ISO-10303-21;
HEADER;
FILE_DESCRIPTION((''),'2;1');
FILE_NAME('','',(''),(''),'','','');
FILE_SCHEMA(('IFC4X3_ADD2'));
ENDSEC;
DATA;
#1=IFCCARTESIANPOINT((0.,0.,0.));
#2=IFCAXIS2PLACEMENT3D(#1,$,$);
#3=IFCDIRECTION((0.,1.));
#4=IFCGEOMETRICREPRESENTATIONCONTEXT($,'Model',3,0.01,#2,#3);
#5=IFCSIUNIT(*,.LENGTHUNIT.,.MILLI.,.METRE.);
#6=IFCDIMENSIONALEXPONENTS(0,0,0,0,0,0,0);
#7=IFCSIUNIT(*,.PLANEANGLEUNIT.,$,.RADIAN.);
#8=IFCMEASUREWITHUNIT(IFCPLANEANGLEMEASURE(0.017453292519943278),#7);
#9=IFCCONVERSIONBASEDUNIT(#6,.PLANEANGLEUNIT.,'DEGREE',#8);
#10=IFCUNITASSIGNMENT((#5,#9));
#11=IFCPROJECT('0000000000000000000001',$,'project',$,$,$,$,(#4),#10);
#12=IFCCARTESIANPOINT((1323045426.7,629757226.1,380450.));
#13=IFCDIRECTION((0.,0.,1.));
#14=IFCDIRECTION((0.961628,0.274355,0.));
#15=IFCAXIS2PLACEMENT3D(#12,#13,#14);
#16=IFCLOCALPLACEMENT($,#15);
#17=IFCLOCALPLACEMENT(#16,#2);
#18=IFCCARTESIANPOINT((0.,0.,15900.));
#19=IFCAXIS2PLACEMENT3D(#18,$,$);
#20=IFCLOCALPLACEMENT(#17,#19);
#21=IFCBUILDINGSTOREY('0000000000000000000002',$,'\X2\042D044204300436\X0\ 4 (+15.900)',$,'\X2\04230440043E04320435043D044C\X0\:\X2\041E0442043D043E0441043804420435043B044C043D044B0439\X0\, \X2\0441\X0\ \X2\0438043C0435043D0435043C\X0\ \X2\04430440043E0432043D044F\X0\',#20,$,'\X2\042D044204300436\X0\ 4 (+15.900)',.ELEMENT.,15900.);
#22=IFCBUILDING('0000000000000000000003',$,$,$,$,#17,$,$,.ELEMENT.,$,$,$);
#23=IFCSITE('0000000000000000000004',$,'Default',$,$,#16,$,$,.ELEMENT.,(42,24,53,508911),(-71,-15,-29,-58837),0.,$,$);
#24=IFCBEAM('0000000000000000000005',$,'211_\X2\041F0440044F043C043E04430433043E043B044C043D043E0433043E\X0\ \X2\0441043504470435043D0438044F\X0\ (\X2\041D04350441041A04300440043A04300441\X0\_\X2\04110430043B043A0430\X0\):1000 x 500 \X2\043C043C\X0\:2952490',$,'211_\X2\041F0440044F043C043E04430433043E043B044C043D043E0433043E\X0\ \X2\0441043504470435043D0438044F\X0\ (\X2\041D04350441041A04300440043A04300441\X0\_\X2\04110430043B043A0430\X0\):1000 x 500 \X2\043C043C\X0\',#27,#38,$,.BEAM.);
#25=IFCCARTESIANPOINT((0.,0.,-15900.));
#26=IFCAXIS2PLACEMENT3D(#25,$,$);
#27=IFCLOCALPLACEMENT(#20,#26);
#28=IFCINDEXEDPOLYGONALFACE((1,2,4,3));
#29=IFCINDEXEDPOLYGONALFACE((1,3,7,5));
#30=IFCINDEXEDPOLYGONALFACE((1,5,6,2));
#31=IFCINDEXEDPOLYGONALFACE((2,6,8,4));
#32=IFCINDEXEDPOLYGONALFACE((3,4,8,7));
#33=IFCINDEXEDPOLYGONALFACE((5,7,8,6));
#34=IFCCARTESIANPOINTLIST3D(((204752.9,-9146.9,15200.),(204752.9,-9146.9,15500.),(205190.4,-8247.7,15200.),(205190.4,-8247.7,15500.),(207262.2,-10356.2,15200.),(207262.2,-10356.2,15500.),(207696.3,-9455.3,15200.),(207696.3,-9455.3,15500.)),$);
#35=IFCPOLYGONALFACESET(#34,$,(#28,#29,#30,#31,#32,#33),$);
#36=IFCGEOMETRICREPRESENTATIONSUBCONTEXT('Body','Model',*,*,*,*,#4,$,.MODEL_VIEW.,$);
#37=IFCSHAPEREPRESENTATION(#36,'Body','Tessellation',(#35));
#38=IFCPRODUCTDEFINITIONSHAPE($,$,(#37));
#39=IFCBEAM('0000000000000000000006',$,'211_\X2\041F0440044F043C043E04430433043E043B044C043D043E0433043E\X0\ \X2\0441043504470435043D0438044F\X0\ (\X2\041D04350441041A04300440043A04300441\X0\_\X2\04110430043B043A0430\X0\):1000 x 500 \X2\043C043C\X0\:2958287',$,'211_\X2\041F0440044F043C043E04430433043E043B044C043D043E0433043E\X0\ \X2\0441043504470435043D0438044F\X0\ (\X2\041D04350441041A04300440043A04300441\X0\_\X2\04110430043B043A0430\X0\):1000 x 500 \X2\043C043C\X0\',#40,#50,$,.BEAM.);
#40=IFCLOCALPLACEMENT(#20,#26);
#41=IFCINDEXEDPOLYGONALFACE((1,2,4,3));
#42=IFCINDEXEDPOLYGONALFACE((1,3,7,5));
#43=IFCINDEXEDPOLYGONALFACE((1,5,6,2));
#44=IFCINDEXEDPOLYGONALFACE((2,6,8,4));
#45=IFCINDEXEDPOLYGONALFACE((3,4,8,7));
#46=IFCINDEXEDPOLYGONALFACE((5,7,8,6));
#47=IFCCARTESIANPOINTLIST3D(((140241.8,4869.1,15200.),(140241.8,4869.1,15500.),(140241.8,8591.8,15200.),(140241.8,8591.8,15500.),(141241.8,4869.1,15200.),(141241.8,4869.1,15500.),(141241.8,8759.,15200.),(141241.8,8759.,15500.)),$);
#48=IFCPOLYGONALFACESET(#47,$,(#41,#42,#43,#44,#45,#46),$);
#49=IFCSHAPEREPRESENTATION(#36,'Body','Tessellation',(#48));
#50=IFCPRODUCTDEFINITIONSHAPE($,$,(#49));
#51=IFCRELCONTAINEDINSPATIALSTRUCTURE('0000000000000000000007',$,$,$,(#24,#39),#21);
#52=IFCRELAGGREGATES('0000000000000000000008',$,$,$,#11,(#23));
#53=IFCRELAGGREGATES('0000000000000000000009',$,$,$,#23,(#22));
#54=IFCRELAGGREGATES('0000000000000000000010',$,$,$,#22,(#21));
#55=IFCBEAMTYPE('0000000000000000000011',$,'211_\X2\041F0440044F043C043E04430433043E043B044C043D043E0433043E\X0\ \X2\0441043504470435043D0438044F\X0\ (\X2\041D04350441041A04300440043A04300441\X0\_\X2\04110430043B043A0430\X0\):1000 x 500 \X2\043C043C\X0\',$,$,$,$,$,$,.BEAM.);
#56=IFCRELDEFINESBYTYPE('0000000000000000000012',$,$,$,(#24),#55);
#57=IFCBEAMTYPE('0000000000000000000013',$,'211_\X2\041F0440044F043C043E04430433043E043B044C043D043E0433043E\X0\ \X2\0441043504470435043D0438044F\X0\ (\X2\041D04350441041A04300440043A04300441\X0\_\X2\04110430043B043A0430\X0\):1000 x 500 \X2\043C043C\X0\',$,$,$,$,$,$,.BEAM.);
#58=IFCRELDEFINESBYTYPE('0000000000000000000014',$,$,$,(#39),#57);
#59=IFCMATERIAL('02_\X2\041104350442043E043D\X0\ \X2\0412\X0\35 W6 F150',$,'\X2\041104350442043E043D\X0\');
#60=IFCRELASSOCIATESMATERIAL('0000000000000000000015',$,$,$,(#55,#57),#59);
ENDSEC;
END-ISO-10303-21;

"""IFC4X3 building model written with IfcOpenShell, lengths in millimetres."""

from ifc_helpers import new_model, entity, si_unit, converted_unit, direction, frame, frame_2d, origin, place, context, subcontext, project, spatial, rectangle, extrude, clip, halfspace, source, transform, mapped, material, material_profile, profile_set, type_object, type_shapes, element, save


model = new_model("IFC4X3")

# Units and contexts
model_context = context("Model", 3, precision=0.01, world=origin(), true_north=direction((0.0, 1.0)))
body_context = subcontext(model_context, "Body", "Model", "MODEL_VIEW")
ifc_project = project(units=[si_unit("LENGTHUNIT", "METRE", prefix="MILLI"), converted_unit("PLANEANGLEUNIT", "DEGREE", entity("IfcPlaneAngleMeasure", 0.017453292519943278), si_unit("PLANEANGLEUNIT", "RADIAN"), dimensions=[0, 0, 0, 0, 0, 0, 0])], contexts=[model_context])

# Site, building, storey
site_placement = place(None, frame((1323045426.7, 629757226.1, 380450.0), z_axis=(0.0, 0.0, 1.0), x_axis=(0.961628, 0.274355, 0.0)))
site = spatial("IfcSite", under=ifc_project, at=site_placement, Name="Default", CompositionType="ELEMENT", RefLatitude=(42, 24, 53, 508911), RefLongitude=(-71, -15, -29, -58837), RefElevation=0.0)
building_placement = place(site_placement, origin())
building = spatial("IfcBuilding", under=site, at=building_placement, CompositionType="ELEMENT")
storey_placement = place(building_placement, frame((0.0, 0.0, 15900.0)))
storey = spatial("IfcBuildingStorey", under=building, at=storey_placement, Name="Этаж 4 (+15.900)", ObjectType="Уровень:Относительный, с именем уровня", LongName="Этаж 4 (+15.900)", CompositionType="ELEMENT", Elevation=15900.0)

# Beams
ifc_material = material(Name="02_Бетон В35 W6 F150", Category="Бетон")
ifc_material_profile_1 = material_profile(ifc_material, rectangle(XDim=300.0, YDim=1000.0, at=frame_2d((0.0, 0.0), x_axis=(1.0, 0.0))), Name="1000 x 500 мм")
ifc_profile_set_1 = profile_set([ifc_material_profile_1], Name="1000 x 500 мм")
beam_type_1 = type_object("IfcBeamType", Name="211_Прямоугольного сечения (НесКаркас_Балка):1000 x 500 мм", PredefinedType="BEAM", material=ifc_profile_set_1)
shared_shape_1 = source(origin(), body_context, "Body", "SweptSolid", [
    clip(extrude(rectangle(XDim=300.0, YDim=1000.0, at=frame_2d((0.0, 0.0), x_axis=(1.0, 0.0))), frame((204969.9, -8696.5, 15350.0), z_axis=(0.900858, -0.434114, 0.0), x_axis=(0.0, 0.0, -1.0)), (0.0, 0.0, 1.0), 2785.5), halfspace(frame((205190.4, -8247.7, 15900.0), z_axis=(-0.899193, 0.437552, 0.0), x_axis=(0.437552, 0.899193, 0.0)), False)),
])
type_shapes(beam_type_1, [shared_shape_1])
beam_1_placement = place(storey_placement, frame((0.0, 0.0, -15900.0)))
element("IfcBeam", 1, at=beam_1_placement, inside=storey, type_object=beam_type_1, Name="211_Прямоугольного сечения (НесКаркас_Балка):1000 x 500 мм:2952490", ObjectType="211_Прямоугольного сечения (НесКаркас_Балка):1000 x 500 мм", PredefinedType="BEAM", context=body_context, shape_type="MappedRepresentation", body=[
    mapped(shared_shape_1, transform((0.0, 0.0, 0.0), scale=1.0)),
])
beam_type_2 = type_object("IfcBeamType", Name="211_Прямоугольного сечения (НесКаркас_Балка):1000 x 500 мм", PredefinedType="BEAM", material=ifc_profile_set_1)
shared_shape_2 = source(origin(), body_context, "Body", "SweptSolid", [
    clip(extrude(rectangle(XDim=300.0, YDim=1000.0, at=frame_2d((0.0, 0.0), x_axis=(0.0, 1.0))), frame((140741.8, 4869.1, 15350.0), z_axis=(0.0, 1.0, 0.0), x_axis=(-1.0, 0.0, 0.0)), (0.0, 0.0, 1.0), 3889.9), halfspace(frame((141323.2, 8772.6, 15200.0), z_axis=(-0.164896, 0.986311, 0.0), x_axis=(0.986311, 0.164896, 0.0)), False)),
])
type_shapes(beam_type_2, [shared_shape_2])
beam_2_placement = place(storey_placement, frame((0.0, 0.0, -15900.0)))
element("IfcBeam", 2, at=beam_2_placement, inside=storey, type_object=beam_type_2, Name="211_Прямоугольного сечения (НесКаркас_Балка):1000 x 500 мм:2958287", ObjectType="211_Прямоугольного сечения (НесКаркас_Балка):1000 x 500 мм", PredefinedType="BEAM", context=body_context, shape_type="MappedRepresentation", body=[
    mapped(shared_shape_2, transform((0.0, 0.0, 0.0), scale=1.0)),
])

save(model, "model.ifc")
